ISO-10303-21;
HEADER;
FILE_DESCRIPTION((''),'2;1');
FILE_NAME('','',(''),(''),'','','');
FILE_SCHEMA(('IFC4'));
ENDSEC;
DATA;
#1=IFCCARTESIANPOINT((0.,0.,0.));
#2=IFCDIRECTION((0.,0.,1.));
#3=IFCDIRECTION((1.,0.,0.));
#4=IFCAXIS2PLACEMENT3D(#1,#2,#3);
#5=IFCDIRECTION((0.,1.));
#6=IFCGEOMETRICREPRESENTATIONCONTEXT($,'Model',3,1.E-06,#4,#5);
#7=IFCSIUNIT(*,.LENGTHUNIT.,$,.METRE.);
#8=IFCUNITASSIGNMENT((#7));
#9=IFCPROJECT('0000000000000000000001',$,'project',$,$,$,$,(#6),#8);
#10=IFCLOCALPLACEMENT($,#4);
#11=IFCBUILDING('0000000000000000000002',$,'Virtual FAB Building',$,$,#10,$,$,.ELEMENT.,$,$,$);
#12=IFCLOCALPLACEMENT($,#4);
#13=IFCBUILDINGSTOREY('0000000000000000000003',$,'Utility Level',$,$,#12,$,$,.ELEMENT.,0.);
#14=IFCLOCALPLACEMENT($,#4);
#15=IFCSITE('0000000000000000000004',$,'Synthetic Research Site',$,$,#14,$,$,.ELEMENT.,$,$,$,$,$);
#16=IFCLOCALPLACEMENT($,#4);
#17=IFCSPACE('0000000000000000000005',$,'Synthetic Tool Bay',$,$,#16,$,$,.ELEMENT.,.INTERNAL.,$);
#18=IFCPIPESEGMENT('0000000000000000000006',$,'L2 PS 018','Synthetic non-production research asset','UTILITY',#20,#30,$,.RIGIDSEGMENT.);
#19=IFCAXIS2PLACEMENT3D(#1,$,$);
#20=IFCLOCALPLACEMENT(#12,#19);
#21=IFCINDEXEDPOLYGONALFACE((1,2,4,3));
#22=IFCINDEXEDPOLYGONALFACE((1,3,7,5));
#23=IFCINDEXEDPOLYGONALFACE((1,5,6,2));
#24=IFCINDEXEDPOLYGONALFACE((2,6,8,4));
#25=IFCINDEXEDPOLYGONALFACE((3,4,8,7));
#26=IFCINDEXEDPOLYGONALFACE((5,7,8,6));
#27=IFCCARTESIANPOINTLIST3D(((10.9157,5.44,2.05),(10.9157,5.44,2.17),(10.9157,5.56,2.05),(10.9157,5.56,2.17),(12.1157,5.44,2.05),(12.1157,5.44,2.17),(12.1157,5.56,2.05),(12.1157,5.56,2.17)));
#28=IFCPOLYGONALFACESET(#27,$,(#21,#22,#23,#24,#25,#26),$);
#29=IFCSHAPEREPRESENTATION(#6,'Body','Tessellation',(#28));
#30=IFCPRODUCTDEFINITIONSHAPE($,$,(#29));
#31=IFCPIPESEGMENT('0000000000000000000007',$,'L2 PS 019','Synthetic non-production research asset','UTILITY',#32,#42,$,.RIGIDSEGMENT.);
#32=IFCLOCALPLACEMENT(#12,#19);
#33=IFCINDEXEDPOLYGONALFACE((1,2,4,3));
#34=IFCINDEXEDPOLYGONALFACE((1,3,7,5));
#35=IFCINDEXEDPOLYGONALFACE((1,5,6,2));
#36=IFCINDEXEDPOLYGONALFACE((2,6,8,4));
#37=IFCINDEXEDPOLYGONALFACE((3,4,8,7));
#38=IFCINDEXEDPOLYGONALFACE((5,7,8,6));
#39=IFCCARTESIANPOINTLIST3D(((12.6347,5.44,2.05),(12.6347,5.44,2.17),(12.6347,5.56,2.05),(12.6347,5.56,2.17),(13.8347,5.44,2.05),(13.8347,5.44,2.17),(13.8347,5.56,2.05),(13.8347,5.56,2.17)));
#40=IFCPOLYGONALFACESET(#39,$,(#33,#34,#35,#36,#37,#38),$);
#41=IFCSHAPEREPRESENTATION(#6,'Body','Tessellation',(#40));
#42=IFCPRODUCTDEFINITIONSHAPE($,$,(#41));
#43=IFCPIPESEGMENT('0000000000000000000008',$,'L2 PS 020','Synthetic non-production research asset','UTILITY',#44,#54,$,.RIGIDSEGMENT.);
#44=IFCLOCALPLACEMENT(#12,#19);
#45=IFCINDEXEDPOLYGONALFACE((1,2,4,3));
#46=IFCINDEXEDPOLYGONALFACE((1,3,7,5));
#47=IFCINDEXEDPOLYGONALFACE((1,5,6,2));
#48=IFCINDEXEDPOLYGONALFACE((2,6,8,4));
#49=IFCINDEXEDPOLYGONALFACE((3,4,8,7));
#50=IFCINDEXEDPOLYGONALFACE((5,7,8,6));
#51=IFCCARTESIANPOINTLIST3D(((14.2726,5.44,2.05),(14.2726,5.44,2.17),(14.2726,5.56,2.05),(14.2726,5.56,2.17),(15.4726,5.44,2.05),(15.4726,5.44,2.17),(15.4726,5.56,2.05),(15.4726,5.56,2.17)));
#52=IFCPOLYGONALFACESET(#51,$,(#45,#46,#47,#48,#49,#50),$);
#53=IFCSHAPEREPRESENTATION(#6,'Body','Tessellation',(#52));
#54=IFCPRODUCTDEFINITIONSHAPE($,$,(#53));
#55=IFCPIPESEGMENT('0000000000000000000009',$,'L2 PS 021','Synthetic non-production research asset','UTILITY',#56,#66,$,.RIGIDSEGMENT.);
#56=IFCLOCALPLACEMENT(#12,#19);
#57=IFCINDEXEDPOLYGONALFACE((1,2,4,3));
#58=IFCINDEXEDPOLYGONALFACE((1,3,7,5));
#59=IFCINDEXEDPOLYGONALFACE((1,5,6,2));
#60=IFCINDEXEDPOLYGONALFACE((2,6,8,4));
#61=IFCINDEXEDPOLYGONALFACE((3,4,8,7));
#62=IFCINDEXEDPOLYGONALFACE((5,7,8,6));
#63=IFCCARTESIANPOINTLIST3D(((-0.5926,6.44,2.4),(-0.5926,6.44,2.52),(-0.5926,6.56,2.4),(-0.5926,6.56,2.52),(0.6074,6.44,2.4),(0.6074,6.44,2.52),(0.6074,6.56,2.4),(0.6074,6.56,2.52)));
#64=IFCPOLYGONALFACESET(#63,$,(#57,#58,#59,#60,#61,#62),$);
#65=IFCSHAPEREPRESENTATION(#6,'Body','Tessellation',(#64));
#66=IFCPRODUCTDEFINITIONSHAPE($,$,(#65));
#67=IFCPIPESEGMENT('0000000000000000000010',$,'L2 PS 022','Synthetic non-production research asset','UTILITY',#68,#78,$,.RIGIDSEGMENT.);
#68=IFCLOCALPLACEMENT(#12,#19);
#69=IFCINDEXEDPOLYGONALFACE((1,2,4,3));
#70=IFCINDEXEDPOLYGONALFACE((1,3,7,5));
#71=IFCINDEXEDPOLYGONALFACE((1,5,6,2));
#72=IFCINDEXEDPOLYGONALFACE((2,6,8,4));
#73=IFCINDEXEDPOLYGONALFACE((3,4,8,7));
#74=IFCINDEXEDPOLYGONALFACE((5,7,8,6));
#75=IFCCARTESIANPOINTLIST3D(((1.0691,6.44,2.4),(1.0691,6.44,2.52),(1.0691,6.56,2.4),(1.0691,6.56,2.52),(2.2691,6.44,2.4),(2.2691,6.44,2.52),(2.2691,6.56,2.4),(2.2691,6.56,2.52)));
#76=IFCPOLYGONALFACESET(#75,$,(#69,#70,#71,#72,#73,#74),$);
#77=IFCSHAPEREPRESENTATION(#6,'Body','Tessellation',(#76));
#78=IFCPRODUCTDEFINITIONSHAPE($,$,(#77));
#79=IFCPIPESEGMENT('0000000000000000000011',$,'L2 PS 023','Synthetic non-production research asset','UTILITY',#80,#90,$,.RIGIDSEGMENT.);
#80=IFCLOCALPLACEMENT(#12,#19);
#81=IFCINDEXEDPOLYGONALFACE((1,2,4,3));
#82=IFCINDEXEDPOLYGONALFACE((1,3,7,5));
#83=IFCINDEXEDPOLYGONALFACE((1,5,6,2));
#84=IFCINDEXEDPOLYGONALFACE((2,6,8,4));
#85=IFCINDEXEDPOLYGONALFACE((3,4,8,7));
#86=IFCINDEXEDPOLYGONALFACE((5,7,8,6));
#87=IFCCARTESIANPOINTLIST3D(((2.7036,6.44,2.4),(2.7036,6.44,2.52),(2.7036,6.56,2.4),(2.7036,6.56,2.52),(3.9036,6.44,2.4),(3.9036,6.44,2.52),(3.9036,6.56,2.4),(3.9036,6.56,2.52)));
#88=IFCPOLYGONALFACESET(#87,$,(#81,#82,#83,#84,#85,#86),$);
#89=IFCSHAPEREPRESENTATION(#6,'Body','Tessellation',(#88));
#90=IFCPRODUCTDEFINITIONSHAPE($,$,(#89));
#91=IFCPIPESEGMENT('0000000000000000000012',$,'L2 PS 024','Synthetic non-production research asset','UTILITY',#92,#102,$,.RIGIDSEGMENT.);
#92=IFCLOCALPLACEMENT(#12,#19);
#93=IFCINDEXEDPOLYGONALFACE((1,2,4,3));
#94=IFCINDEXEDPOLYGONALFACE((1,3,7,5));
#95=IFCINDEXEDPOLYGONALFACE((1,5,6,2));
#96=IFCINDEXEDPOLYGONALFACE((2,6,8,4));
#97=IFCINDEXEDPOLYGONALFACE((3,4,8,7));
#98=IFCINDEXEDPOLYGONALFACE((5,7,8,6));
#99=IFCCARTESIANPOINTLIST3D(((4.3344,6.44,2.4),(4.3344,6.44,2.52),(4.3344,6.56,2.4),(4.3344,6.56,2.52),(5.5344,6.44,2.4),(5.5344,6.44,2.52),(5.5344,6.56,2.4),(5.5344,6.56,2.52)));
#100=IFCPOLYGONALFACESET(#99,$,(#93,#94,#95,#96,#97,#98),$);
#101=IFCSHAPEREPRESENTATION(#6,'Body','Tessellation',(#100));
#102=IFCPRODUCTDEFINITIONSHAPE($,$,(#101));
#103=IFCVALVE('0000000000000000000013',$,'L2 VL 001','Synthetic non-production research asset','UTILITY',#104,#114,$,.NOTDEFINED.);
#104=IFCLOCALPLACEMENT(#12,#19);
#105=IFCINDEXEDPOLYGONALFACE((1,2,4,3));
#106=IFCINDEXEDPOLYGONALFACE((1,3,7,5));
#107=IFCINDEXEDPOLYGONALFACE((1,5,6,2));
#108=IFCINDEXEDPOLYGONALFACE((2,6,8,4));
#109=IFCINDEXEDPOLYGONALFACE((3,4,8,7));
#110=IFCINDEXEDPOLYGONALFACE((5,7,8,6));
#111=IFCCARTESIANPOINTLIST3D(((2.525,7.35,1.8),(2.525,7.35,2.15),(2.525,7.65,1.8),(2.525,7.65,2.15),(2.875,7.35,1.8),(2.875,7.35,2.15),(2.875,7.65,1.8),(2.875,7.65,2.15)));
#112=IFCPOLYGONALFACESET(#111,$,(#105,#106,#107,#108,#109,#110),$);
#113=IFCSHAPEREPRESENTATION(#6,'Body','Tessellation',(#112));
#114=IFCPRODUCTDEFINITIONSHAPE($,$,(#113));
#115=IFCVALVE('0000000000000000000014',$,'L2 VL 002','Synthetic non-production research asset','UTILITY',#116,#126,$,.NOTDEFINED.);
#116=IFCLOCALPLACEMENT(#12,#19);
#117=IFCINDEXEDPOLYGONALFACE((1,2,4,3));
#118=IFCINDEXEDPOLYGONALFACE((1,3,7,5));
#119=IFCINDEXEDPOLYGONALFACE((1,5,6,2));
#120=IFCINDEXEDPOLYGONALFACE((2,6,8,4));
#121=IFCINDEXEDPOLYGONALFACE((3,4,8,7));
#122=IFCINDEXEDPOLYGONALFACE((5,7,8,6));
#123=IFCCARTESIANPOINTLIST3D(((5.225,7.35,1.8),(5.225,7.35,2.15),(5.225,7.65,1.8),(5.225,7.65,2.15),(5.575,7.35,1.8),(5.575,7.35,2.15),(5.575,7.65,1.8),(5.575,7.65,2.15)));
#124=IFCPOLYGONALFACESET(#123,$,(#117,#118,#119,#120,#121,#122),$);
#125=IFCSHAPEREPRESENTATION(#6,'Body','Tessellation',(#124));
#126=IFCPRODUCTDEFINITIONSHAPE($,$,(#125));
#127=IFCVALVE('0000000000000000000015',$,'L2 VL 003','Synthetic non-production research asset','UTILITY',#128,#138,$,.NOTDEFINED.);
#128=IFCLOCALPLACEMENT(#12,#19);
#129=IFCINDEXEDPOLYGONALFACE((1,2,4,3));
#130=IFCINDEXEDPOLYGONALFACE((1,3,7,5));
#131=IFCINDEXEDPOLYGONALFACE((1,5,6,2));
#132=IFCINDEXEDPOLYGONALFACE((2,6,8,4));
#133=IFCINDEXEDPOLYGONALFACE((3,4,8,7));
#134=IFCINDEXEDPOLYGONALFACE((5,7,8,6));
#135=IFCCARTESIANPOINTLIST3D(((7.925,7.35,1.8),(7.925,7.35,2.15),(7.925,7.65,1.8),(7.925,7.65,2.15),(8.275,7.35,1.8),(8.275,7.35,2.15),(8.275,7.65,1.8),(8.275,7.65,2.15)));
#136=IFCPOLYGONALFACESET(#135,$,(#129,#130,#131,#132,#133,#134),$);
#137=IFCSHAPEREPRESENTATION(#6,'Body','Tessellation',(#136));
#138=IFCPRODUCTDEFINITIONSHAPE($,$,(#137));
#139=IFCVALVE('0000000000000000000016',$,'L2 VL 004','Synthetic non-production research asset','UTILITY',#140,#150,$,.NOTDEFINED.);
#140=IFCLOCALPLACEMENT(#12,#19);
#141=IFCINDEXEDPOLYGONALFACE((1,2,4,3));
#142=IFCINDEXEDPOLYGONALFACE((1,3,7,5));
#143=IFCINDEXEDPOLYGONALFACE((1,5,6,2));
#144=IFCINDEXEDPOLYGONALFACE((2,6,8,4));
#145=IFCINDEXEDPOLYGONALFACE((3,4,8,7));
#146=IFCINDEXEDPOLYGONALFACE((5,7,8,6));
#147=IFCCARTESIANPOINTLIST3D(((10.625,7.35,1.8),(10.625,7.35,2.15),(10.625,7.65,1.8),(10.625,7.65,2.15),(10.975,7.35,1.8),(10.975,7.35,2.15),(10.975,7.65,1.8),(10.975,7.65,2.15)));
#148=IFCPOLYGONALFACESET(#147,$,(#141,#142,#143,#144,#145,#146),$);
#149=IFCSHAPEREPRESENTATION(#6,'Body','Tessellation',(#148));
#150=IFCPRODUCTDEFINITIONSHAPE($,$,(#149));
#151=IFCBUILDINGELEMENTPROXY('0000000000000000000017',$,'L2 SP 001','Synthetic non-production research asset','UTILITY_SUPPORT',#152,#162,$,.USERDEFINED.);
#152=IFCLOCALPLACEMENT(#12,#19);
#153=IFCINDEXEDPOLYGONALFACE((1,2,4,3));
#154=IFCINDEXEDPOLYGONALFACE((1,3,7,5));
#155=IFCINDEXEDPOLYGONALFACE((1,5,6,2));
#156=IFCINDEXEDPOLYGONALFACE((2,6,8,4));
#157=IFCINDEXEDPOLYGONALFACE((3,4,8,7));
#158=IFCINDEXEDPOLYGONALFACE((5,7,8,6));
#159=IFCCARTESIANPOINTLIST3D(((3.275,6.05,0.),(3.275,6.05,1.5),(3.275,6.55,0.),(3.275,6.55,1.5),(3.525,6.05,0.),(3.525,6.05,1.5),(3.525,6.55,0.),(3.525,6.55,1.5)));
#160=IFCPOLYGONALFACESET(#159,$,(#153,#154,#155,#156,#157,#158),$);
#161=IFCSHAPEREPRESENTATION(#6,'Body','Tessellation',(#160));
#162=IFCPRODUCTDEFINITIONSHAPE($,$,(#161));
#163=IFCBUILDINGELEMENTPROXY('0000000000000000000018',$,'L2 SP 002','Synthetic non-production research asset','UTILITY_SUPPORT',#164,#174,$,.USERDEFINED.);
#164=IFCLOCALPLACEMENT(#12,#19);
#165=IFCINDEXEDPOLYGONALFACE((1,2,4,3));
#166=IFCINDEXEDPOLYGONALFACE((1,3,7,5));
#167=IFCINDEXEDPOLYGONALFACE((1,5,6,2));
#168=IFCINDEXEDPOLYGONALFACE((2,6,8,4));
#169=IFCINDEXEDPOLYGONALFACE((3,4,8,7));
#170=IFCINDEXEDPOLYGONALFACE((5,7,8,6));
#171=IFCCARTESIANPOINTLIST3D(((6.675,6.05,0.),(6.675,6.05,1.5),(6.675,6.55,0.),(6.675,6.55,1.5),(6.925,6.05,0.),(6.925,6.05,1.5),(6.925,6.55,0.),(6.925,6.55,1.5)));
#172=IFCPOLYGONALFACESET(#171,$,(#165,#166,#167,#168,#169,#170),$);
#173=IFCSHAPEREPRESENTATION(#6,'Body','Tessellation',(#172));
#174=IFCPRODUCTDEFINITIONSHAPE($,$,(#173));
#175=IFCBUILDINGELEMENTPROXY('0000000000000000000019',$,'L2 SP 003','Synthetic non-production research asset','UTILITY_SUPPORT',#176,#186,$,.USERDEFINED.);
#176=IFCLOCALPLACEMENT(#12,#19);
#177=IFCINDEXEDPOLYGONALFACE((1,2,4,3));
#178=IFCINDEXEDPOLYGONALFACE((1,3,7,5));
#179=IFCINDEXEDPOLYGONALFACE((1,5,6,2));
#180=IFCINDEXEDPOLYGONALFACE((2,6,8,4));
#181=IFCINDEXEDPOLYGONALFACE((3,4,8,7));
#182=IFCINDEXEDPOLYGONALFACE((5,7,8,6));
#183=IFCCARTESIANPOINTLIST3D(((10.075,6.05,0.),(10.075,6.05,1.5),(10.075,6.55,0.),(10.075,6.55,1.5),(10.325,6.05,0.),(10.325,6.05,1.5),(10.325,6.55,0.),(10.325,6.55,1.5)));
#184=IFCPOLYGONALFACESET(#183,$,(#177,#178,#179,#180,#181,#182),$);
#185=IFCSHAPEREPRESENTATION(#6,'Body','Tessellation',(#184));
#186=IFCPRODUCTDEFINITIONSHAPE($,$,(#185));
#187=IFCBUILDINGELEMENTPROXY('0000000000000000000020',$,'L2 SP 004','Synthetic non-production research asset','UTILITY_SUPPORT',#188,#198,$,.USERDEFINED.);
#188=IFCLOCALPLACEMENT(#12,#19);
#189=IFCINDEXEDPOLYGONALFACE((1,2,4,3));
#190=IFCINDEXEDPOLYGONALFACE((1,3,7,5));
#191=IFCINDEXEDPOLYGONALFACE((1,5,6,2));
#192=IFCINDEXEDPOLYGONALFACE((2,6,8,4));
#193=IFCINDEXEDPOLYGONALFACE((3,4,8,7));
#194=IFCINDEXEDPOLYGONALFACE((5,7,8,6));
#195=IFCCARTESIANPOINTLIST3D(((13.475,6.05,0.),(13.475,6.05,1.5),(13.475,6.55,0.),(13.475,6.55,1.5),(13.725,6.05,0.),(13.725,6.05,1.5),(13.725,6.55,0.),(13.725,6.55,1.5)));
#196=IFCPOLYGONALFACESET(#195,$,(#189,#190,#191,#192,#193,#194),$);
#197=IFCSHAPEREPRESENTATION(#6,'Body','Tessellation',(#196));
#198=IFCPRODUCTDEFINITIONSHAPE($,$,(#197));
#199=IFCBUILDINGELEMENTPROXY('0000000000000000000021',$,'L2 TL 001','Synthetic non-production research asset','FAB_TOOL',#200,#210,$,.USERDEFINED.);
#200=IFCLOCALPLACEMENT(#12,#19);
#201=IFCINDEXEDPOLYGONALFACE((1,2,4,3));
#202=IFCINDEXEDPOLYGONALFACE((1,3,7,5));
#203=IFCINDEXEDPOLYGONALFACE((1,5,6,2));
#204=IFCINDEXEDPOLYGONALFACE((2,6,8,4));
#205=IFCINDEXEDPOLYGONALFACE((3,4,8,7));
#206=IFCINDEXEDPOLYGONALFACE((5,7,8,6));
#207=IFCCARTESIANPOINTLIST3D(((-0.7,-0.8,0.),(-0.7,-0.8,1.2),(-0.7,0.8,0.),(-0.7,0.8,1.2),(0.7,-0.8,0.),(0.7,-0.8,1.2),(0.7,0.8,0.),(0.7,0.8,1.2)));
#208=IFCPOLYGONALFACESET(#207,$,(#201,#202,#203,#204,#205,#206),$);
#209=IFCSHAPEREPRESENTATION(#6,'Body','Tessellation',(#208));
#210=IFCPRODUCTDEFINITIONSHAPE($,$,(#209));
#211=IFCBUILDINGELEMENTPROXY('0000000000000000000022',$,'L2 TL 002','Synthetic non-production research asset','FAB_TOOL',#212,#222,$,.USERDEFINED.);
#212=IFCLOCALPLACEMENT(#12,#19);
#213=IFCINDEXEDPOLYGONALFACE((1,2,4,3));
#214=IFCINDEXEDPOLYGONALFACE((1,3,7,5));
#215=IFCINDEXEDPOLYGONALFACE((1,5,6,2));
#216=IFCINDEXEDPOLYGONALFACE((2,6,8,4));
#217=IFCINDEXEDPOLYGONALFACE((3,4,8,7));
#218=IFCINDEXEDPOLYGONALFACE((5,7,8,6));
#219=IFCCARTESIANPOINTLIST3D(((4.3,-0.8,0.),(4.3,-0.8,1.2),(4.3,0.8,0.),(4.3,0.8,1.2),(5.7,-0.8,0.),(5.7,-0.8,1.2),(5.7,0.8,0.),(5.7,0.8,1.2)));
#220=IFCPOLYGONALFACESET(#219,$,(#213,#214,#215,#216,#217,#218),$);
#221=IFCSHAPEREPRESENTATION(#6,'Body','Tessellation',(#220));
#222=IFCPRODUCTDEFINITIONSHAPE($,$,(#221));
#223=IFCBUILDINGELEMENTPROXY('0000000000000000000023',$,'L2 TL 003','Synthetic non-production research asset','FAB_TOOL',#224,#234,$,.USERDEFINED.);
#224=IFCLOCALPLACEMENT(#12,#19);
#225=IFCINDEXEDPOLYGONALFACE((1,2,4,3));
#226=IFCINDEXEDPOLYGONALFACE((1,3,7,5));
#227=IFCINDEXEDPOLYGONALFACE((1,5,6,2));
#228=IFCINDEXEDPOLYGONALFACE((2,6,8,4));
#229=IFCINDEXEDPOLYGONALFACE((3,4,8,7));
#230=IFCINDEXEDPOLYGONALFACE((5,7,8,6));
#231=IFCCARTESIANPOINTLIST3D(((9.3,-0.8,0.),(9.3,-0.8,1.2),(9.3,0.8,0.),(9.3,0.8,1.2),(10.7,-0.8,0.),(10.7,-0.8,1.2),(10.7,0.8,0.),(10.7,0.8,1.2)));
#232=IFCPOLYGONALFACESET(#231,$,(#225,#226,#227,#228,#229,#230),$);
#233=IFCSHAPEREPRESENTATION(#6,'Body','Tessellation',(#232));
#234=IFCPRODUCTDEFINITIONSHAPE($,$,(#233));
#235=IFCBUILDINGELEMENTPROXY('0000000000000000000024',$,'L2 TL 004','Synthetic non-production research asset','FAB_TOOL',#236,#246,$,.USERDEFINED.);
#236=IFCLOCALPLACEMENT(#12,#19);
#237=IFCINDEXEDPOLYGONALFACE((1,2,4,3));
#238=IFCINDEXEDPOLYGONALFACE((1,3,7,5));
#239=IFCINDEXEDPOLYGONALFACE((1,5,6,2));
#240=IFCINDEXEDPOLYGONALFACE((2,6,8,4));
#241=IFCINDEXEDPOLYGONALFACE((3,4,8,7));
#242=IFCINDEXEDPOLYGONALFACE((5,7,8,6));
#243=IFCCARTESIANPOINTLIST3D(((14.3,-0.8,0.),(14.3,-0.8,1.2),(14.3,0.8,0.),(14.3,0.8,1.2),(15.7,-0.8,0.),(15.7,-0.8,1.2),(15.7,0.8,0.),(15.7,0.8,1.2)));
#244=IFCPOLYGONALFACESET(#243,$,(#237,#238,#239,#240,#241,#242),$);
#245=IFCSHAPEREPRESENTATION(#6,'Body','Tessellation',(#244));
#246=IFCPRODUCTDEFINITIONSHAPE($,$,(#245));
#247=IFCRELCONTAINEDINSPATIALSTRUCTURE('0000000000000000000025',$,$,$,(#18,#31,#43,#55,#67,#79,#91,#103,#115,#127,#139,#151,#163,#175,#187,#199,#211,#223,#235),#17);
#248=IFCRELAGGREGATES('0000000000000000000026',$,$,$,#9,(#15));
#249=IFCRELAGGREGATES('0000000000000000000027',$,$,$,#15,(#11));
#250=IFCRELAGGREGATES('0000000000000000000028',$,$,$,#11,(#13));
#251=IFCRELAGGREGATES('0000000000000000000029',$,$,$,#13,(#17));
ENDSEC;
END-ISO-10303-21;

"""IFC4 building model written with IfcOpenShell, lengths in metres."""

from ifc_helpers import new_model, si_unit, direction, frame, origin_with_axes, origin_2d_with_axis, place, context, project, spatial, rectangle, extrude, element, save


model = new_model("IFC4")

# Units and contexts
model_context = context("Model", 3, precision=1e-06, world=origin_with_axes(), true_north=direction((0.0, 1.0)))
ifc_project = project(units=[si_unit("LENGTHUNIT", "METRE")], contexts=[model_context])

# Site, building, storey, space
site_placement = place(None, origin_with_axes())
site = spatial("IfcSite", under=ifc_project, at=site_placement, Name="Synthetic Research Site", CompositionType="ELEMENT")
building_placement = place(None, origin_with_axes())
building = spatial("IfcBuilding", under=site, at=building_placement, Name="Virtual FAB Building", CompositionType="ELEMENT")
storey_placement = place(None, origin_with_axes())
storey = spatial("IfcBuildingStorey", under=building, at=storey_placement, Name="Utility Level", CompositionType="ELEMENT", Elevation=0.0)
space_placement = place(None, origin_with_axes())
space = spatial("IfcSpace", under=storey, at=space_placement, Name="Synthetic Tool Bay", CompositionType="ELEMENT", PredefinedType="INTERNAL")

# Pipe segments
for number, where, z_axis, x_axis, name in (
    (1, (11.5157, 5.5, 2.05), (0.0, 0.0, 1.0), (1.0, 0.0, 0.0), "L2 PS 018"),
    (2, (13.2347, 5.5, 2.05), (0.0, 0.0, 1.0), (1.0, 0.0, 0.0), "L2 PS 019"),
    (3, (14.8726, 5.5, 2.05), (0.0, 0.0, 1.0), (1.0, 0.0, 0.0), "L2 PS 020"),
    (4, (0.0074, 6.5, 2.4), (0.0, 0.0, 1.0), (1.0, 0.0, 0.0), "L2 PS 021"),
    (5, (1.6691, 6.5, 2.4), (0.0, 0.0, 1.0), (1.0, 0.0, 0.0), "L2 PS 022"),
    (6, (3.3036, 6.5, 2.4), (0.0, 0.0, 1.0), (1.0, 0.0, 0.0), "L2 PS 023"),
    (7, (4.9344, 6.5, 2.4), (0.0, 0.0, 1.0), (1.0, 0.0, 0.0), "L2 PS 024"),
):
    element("IfcPipeSegment", number, at=place(None, frame(where, z_axis=z_axis, x_axis=x_axis)), inside=space, Name=name, Description="Synthetic non-production research asset", ObjectType="UTILITY", PredefinedType="RIGIDSEGMENT", context=model_context, shape_type="SweptSolid", body=[
        extrude(rectangle(XDim=1.2, YDim=0.12, at=origin_2d_with_axis()), origin_with_axes(), (0.0, 0.0, 1.0), 0.12),
    ])

# Valves
for number, where, z_axis, x_axis, name in (
    (8, (2.7, 7.5, 1.8), (0.0, 0.0, 1.0), (1.0, 0.0, 0.0), "L2 VL 001"),
    (9, (5.4, 7.5, 1.8), (0.0, 0.0, 1.0), (1.0, 0.0, 0.0), "L2 VL 002"),
    (10, (8.1, 7.5, 1.8), (0.0, 0.0, 1.0), (1.0, 0.0, 0.0), "L2 VL 003"),
    (11, (10.8, 7.5, 1.8), (0.0, 0.0, 1.0), (1.0, 0.0, 0.0), "L2 VL 004"),
):
    element("IfcValve", number, at=place(None, frame(where, z_axis=z_axis, x_axis=x_axis)), inside=space, Name=name, Description="Synthetic non-production research asset", ObjectType="UTILITY", PredefinedType="NOTDEFINED", context=model_context, shape_type="SweptSolid", body=[
        extrude(rectangle(XDim=0.35, YDim=0.3, at=origin_2d_with_axis()), origin_with_axes(), (0.0, 0.0, 1.0), 0.35),
    ])

# Building element proxies
for number, where, z_axis, x_axis, name in (
    (12, (3.4, 6.3, 0.0), (0.0, 0.0, 1.0), (1.0, 0.0, 0.0), "L2 SP 001"),
    (13, (6.8, 6.3, 0.0), (0.0, 0.0, 1.0), (1.0, 0.0, 0.0), "L2 SP 002"),
    (14, (10.2, 6.3, 0.0), (0.0, 0.0, 1.0), (1.0, 0.0, 0.0), "L2 SP 003"),
    (15, (13.6, 6.3, 0.0), (0.0, 0.0, 1.0), (1.0, 0.0, 0.0), "L2 SP 004"),
):
    element("IfcBuildingElementProxy", number, at=place(None, frame(where, z_axis=z_axis, x_axis=x_axis)), inside=space, Name=name, Description="Synthetic non-production research asset", ObjectType="UTILITY_SUPPORT", PredefinedType="USERDEFINED", context=model_context, shape_type="SweptSolid", body=[
        extrude(rectangle(XDim=0.25, YDim=0.5, at=origin_2d_with_axis()), origin_with_axes(), (0.0, 0.0, 1.0), 1.5),
    ])
for number, where, z_axis, x_axis, name in (
    (16, (0.0, 0.0, 0.0), (0.0, 0.0, 1.0), (1.0, 0.0, 0.0), "L2 TL 001"),
    (17, (5.0, 0.0, 0.0), (0.0, 0.0, 1.0), (1.0, 0.0, 0.0), "L2 TL 002"),
    (18, (10.0, 0.0, 0.0), (0.0, 0.0, 1.0), (1.0, 0.0, 0.0), "L2 TL 003"),
    (19, (15.0, 0.0, 0.0), (0.0, 0.0, 1.0), (1.0, 0.0, 0.0), "L2 TL 004"),
):
    element("IfcBuildingElementProxy", number, at=place(None, frame(where, z_axis=z_axis, x_axis=x_axis)), inside=space, Name=name, Description="Synthetic non-production research asset", ObjectType="FAB_TOOL", PredefinedType="USERDEFINED", context=model_context, shape_type="SweptSolid", body=[
        extrude(rectangle(XDim=1.4, YDim=1.6, at=origin_2d_with_axis()), origin_with_axes(), (0.0, 0.0, 1.0), 1.2),
    ])

save(model, "model.ifc")
